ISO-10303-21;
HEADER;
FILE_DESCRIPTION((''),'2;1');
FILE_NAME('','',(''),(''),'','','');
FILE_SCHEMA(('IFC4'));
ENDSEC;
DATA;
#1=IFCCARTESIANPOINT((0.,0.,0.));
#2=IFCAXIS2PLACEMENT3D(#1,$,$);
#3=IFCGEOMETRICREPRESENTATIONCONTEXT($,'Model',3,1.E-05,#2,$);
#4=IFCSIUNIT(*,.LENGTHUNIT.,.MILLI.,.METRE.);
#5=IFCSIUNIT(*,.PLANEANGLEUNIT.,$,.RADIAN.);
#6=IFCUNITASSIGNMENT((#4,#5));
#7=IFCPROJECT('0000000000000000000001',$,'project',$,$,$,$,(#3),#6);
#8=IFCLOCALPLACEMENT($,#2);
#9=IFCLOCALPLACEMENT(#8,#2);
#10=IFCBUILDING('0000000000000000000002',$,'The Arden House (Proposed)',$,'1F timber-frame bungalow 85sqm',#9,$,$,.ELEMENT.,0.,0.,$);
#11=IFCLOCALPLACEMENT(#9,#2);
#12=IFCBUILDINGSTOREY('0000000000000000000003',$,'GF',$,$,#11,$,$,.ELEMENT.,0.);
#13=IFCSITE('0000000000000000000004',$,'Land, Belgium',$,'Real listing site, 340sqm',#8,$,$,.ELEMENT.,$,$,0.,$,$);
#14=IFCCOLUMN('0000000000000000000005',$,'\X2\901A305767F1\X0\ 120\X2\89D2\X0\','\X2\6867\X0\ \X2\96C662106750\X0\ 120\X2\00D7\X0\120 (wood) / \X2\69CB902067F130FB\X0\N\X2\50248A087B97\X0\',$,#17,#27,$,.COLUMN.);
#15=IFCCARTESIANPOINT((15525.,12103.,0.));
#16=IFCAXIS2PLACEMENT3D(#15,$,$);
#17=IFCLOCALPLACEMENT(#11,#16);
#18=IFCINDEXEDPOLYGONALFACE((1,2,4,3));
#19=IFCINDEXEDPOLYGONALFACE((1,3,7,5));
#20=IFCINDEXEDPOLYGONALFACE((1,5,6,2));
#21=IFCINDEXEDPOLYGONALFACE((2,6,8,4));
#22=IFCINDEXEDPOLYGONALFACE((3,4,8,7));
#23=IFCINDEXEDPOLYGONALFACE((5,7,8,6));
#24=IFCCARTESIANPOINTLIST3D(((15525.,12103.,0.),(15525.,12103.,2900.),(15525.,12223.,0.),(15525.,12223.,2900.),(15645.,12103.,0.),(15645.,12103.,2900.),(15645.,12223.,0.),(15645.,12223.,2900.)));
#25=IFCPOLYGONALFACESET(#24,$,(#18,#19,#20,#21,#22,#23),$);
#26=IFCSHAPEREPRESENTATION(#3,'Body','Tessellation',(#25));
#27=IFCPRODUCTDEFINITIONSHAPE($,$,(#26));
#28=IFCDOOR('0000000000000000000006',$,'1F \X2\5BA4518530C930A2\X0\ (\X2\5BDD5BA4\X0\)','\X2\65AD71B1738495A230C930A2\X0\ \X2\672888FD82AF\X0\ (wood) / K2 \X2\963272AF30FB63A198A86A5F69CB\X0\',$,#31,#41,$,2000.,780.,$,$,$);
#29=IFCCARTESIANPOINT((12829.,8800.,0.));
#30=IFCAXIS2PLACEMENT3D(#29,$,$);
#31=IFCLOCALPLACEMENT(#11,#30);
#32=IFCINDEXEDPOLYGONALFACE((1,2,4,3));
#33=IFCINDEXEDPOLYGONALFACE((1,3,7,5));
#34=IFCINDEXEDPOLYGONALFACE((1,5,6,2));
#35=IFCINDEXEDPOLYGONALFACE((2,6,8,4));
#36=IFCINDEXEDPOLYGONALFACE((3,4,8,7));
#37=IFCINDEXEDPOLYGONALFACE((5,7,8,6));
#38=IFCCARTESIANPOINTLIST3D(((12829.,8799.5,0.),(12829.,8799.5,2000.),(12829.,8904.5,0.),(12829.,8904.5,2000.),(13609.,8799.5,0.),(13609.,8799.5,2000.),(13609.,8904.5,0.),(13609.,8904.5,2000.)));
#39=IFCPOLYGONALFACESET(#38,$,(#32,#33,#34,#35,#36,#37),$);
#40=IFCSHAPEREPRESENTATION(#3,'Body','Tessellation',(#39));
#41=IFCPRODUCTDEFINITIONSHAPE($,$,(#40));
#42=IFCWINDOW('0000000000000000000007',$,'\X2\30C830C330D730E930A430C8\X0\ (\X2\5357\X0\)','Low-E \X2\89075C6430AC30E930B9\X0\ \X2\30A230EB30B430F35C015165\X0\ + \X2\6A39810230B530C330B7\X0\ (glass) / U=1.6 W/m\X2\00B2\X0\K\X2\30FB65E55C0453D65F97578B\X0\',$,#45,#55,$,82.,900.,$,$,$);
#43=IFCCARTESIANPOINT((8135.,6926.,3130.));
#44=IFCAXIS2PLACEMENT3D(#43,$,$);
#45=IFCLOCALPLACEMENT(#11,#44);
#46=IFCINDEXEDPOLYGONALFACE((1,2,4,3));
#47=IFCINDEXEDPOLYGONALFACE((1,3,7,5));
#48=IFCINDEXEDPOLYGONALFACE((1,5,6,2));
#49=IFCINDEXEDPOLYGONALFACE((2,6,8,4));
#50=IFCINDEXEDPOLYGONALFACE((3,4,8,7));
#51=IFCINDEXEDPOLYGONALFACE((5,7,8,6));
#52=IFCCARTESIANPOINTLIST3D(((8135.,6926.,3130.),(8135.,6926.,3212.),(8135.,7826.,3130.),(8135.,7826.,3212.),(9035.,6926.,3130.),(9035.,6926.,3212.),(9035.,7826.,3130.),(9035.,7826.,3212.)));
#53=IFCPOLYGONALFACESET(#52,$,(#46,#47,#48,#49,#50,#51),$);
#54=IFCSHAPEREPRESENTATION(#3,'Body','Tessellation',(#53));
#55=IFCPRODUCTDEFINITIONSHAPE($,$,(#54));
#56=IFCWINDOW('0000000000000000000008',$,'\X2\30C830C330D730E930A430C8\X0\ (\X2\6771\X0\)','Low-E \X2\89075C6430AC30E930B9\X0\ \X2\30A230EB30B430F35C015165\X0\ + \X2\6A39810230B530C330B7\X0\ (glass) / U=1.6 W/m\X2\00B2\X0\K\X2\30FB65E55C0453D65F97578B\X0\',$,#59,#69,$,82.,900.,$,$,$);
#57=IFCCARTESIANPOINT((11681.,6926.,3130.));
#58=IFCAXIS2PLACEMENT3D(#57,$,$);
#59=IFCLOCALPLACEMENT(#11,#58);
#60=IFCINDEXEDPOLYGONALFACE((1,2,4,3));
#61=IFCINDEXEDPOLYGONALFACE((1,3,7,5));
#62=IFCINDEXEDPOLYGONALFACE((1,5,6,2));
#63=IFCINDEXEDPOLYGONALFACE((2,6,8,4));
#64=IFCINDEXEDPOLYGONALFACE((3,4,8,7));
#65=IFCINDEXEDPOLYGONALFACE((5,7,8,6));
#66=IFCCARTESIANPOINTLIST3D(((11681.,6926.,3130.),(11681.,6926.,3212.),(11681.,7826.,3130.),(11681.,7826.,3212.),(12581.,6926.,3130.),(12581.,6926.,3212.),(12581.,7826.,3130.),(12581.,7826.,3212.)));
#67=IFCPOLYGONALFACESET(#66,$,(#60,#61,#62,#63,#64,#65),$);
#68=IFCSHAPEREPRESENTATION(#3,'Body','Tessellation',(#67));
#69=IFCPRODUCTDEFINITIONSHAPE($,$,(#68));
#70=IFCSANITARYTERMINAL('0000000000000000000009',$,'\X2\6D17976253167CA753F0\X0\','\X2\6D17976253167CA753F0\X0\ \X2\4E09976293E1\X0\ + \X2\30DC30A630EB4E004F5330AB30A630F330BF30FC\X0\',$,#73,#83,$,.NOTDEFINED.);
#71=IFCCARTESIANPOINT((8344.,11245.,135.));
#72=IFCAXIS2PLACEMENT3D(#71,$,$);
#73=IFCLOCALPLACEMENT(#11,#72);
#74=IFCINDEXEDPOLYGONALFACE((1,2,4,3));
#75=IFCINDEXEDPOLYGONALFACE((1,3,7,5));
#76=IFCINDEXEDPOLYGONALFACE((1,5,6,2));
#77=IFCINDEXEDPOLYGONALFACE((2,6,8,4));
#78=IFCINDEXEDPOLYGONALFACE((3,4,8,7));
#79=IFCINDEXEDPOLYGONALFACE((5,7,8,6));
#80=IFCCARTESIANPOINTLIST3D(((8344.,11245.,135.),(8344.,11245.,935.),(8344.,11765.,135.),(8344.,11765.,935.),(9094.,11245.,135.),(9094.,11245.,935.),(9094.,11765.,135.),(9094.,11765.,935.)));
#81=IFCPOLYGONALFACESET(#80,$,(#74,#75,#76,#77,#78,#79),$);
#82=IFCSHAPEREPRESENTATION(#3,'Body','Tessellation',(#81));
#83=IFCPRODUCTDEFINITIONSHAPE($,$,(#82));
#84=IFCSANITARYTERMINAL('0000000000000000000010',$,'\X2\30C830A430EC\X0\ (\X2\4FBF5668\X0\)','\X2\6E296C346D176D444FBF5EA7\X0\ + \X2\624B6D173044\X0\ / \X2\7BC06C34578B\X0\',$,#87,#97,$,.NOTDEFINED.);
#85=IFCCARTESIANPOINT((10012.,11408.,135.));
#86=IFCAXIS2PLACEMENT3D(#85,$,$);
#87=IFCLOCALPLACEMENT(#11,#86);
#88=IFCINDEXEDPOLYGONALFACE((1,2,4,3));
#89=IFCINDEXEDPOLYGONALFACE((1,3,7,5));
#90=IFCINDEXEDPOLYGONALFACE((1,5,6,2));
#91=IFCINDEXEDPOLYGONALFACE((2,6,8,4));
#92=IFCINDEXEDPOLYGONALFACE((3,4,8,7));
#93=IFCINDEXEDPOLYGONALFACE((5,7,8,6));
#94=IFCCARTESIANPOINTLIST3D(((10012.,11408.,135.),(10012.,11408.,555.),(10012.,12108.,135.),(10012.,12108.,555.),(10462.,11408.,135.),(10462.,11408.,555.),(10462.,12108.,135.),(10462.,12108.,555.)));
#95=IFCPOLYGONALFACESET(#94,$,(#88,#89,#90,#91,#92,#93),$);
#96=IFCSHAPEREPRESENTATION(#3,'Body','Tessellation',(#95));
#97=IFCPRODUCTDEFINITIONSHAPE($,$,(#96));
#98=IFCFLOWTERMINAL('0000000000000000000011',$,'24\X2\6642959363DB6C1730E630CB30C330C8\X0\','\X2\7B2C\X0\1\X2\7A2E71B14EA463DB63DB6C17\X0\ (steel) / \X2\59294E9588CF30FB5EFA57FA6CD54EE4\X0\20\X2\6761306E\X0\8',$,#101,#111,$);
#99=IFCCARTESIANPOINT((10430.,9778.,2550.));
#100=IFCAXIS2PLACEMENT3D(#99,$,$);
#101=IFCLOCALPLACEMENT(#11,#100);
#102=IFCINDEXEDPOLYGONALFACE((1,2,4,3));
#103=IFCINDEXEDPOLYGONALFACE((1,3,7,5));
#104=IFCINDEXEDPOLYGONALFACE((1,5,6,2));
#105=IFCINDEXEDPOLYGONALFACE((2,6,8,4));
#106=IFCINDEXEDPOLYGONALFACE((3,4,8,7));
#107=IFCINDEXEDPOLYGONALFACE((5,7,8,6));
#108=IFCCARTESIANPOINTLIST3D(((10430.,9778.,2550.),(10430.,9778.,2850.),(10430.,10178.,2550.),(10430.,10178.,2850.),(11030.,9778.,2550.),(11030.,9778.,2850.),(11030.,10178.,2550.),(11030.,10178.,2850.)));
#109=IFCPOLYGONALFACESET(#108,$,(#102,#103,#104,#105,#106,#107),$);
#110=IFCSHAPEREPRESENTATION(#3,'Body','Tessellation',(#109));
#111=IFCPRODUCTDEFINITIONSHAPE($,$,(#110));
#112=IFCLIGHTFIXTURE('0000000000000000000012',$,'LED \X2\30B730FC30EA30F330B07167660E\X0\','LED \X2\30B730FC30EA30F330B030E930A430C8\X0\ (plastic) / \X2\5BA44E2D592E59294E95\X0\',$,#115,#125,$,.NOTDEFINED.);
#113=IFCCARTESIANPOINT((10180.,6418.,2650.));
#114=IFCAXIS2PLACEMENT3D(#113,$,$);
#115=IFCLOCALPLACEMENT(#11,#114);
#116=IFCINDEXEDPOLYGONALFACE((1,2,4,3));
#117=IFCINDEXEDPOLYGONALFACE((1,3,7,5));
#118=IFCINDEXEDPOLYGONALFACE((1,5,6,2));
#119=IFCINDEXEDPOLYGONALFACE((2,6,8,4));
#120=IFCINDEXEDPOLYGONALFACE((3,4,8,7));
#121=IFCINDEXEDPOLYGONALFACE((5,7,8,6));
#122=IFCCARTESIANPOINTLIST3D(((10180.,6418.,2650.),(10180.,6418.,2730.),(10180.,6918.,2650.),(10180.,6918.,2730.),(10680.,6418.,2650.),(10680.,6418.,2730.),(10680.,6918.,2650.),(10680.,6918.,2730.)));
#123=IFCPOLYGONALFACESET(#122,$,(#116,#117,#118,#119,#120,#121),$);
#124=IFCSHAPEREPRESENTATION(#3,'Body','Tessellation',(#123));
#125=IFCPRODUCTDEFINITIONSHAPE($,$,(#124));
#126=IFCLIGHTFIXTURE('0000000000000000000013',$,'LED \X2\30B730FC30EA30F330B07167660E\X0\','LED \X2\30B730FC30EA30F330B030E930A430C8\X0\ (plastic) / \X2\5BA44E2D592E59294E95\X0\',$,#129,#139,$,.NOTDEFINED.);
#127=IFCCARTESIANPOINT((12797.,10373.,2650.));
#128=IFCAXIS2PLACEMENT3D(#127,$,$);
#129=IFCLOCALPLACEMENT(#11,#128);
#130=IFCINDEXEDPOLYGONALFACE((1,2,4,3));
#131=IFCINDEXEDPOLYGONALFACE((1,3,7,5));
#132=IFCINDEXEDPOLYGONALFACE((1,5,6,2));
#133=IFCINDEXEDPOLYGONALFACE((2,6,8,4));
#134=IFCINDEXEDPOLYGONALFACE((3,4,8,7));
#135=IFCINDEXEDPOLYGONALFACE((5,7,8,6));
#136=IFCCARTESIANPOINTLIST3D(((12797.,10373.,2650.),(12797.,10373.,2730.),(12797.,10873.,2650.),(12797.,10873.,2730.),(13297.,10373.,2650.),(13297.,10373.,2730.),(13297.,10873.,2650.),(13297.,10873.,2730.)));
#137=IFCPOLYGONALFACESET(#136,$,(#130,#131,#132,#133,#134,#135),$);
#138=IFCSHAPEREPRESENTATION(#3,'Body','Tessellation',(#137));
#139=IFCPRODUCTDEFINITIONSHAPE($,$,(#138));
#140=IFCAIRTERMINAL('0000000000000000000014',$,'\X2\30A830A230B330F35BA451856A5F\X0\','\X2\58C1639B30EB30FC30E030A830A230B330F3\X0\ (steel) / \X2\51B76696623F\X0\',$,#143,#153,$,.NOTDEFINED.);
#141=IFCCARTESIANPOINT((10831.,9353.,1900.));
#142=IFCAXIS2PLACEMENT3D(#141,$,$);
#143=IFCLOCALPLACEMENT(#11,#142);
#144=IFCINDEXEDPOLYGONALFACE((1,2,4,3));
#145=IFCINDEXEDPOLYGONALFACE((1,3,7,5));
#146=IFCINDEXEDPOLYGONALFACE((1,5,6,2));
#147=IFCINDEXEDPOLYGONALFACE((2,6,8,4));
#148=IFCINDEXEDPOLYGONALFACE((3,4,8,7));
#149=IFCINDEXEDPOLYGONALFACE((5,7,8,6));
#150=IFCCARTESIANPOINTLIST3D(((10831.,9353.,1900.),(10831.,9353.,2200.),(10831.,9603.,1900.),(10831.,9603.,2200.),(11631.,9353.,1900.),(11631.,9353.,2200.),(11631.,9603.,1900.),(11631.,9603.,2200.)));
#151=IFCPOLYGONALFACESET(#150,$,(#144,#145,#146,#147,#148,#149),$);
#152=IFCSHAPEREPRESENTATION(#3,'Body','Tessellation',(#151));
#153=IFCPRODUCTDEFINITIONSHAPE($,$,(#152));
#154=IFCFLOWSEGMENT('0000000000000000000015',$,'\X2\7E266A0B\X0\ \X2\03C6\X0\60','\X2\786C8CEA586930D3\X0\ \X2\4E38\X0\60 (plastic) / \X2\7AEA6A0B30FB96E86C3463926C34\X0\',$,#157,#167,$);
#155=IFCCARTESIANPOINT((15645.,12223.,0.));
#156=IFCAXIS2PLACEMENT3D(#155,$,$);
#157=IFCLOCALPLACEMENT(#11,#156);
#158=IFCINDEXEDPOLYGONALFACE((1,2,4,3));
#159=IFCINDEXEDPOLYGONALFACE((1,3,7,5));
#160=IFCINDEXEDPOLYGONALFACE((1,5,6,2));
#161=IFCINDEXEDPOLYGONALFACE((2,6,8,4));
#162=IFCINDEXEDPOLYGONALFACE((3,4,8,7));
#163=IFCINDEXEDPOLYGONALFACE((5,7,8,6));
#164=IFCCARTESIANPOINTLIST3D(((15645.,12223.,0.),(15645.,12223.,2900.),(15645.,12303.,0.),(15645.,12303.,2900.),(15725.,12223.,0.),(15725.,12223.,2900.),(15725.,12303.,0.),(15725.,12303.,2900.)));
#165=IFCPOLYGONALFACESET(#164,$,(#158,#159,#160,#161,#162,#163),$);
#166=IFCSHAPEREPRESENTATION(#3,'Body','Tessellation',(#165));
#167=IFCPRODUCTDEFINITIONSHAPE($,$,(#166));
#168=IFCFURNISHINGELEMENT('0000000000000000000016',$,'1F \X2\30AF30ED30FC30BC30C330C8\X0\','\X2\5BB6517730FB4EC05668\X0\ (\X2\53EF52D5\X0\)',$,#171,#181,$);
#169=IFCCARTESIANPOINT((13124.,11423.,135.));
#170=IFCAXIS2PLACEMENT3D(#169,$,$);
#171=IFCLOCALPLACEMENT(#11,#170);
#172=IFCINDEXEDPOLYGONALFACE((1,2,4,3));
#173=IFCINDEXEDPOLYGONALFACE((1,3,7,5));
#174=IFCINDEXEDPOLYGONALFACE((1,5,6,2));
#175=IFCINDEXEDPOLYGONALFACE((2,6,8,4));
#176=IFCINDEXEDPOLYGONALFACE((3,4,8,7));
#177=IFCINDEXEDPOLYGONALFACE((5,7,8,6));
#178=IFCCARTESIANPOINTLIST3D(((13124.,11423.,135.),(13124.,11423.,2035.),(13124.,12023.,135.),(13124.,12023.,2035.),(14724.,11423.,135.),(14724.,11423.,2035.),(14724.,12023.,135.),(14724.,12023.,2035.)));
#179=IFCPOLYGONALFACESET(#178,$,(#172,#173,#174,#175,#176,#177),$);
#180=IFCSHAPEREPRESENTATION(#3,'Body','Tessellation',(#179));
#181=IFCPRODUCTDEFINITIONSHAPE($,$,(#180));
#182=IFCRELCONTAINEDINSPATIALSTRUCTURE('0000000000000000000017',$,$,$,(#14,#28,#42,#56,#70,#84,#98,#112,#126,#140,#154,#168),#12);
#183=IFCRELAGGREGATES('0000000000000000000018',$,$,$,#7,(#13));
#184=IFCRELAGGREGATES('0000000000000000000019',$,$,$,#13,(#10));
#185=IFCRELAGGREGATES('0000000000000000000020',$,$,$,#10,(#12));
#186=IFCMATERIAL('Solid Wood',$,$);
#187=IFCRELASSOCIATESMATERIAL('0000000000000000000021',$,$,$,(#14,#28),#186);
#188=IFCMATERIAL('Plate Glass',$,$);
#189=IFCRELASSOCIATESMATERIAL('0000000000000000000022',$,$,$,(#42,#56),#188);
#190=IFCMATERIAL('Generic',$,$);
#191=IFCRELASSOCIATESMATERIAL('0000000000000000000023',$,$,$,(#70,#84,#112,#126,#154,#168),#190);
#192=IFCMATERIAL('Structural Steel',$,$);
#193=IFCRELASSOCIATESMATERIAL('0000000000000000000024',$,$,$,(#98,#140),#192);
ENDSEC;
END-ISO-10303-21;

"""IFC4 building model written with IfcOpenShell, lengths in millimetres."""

from ifc_helpers import new_model, si_unit, frame, frame_2d, origin, place, context, project, spatial, rectangle, extrude, material, element, save


model = new_model("IFC4")

# Units and contexts
model_context = context("Model", 3, precision=1e-05, world=origin())
ifc_project = project(units=[si_unit("LENGTHUNIT", "METRE", prefix="MILLI"), si_unit("PLANEANGLEUNIT", "RADIAN")], contexts=[model_context])

# Site, building, storey
site_placement = place(None, origin())
site = spatial("IfcSite", under=ifc_project, at=site_placement, Name="Land, Belgium", ObjectType="Real listing site, 340sqm", CompositionType="ELEMENT", RefElevation=0.0)
building_placement = place(site_placement, origin())
building = spatial("IfcBuilding", under=site, at=building_placement, Name="The Arden House (Proposed)", ObjectType="1F timber-frame bungalow 85sqm", CompositionType="ELEMENT", ElevationOfRefHeight=0.0, ElevationOfTerrain=0.0)
storey_placement = place(building_placement, origin())
storey = spatial("IfcBuildingStorey", under=building, at=storey_placement, Name="GF", CompositionType="ELEMENT", Elevation=0.0)

# Column
ifc_material_1 = material(Name="Solid Wood")
column_1_placement = place(storey_placement, frame((15525.0, 12103.0, 0.0)))
element("IfcColumn", 1, at=column_1_placement, inside=storey, material=ifc_material_1, Name="通し柱 120角", Description="桧 集成材 120×120 (wood) / 構造柱・N値計算", PredefinedType="COLUMN", context=model_context, shape_type="SweptSolid", body=[
    extrude(rectangle(XDim=120.0, YDim=120.0, at=frame_2d((60.0, 60.0))), frame((15525.0, 12103.0, 0.0)), (0.0, 0.0, 1.0), 2900.0),
])

# Door
door_placement = place(storey_placement, frame((12829.0, 8800.0, 0.0)))
element("IfcDoor", 2, at=door_placement, inside=storey, material=ifc_material_1, Name="1F 室内ドア (寝室)", Description="断熱玄関ドア 木製芯 (wood) / K2 防犯・採風機構", OverallHeight=2000.0, OverallWidth=780.0, context=model_context, shape_type="SweptSolid", body=[
    extrude(rectangle(XDim=780.0, YDim=105.0, at=frame_2d((390.0, 52.0))), frame((12829.0, 8800.0, 0.0)), (0.0, 0.0, 1.0), 2000.0),
])

# Windows
ifc_material_2 = material(Name="Plate Glass")
window_1_placement = place(storey_placement, frame((8135.0, 6926.0, 3130.0)))
element("IfcWindow", 3, at=window_1_placement, inside=storey, material=ifc_material_2, Name="トップライト (南)", Description="Low-E 複層ガラス アルゴン封入 + 樹脂サッシ (glass) / U=1.6 W/m²K・日射取得型", OverallHeight=82.0, OverallWidth=900.0, context=model_context, shape_type="SweptSolid", body=[
    extrude(rectangle(XDim=900.0, YDim=900.0, at=frame_2d((450.0, 450.0))), frame((8135.0, 6926.0, 3130.0)), (0.0, 0.0, 1.0), 82.0),
])
window_2_placement = place(storey_placement, frame((11681.0, 6926.0, 3130.0)))
element("IfcWindow", 4, at=window_2_placement, inside=storey, material=ifc_material_2, Name="トップライト (東)", Description="Low-E 複層ガラス アルゴン封入 + 樹脂サッシ (glass) / U=1.6 W/m²K・日射取得型", OverallHeight=82.0, OverallWidth=900.0, context=model_context, shape_type="SweptSolid", body=[
    extrude(rectangle(XDim=900.0, YDim=900.0, at=frame_2d((450.0, 450.0))), frame((11681.0, 6926.0, 3130.0)), (0.0, 0.0, 1.0), 82.0),
])

# Sanitary terminals
ifc_material_3 = material(Name="Generic")
sanitary_terminal_1_placement = place(storey_placement, frame((8344.0, 11245.0, 135.0)))
element("IfcSanitaryTerminal", 5, at=sanitary_terminal_1_placement, inside=storey, material=ifc_material_3, Name="洗面化粧台", Description="洗面化粧台 三面鏡 + ボウル一体カウンター", PredefinedType="NOTDEFINED", context=model_context, shape_type="SweptSolid", body=[
    extrude(rectangle(XDim=750.0, YDim=520.0, at=frame_2d((375.0, 260.0))), frame((8344.0, 11245.0, 135.0)), (0.0, 0.0, 1.0), 800.0),
])
sanitary_terminal_2_placement = place(storey_placement, frame((10012.0, 11408.0, 135.0)))
element("IfcSanitaryTerminal", 6, at=sanitary_terminal_2_placement, inside=storey, material=ifc_material_3, Name="トイレ (便器)", Description="温水洗浄便座 + 手洗い / 節水型", PredefinedType="NOTDEFINED", context=model_context, shape_type="SweptSolid", body=[
    extrude(rectangle(XDim=450.0, YDim=700.0, at=frame_2d((225.0, 350.0))), frame((10012.0, 11408.0, 135.0)), (0.0, 0.0, 1.0), 420.0),
])

# Flow terminal
ifc_material_4 = material(Name="Structural Steel")
flow_terminal_placement = place(storey_placement, frame((10430.0, 9778.0, 2550.0)))
element("IfcFlowTerminal", 7, at=flow_terminal_placement, inside=storey, material=ifc_material_4, Name="24時間換気ユニット", Description="第1種熱交換換気 (steel) / 天井裏・建基法令20条の8", context=model_context, shape_type="SweptSolid", body=[
    extrude(rectangle(XDim=600.0, YDim=400.0, at=frame_2d((300.0, 200.0))), frame((10430.0, 9778.0, 2550.0)), (0.0, 0.0, 1.0), 300.0),
])

# Light fixtures
light_fixture_1_placement = place(storey_placement, frame((10180.0, 6418.0, 2650.0)))
element("IfcLightFixture", 8, at=light_fixture_1_placement, inside=storey, material=ifc_material_3, Name="LED シーリング照明", Description="LED シーリングライト (plastic) / 室中央天井", PredefinedType="NOTDEFINED", context=model_context, shape_type="SweptSolid", body=[
    extrude(rectangle(XDim=500.0, YDim=500.0, at=frame_2d((250.0, 250.0))), frame((10180.0, 6418.0, 2650.0)), (0.0, 0.0, 1.0), 80.0),
])
light_fixture_2_placement = place(storey_placement, frame((12797.0, 10373.0, 2650.0)))
element("IfcLightFixture", 9, at=light_fixture_2_placement, inside=storey, material=ifc_material_3, Name="LED シーリング照明", Description="LED シーリングライト (plastic) / 室中央天井", PredefinedType="NOTDEFINED", context=model_context, shape_type="SweptSolid", body=[
    extrude(rectangle(XDim=500.0, YDim=500.0, at=frame_2d((250.0, 250.0))), frame((12797.0, 10373.0, 2650.0)), (0.0, 0.0, 1.0), 80.0),
])

# Air terminal
air_terminal_placement = place(storey_placement, frame((10831.0, 9353.0, 1900.0)))
element("IfcAirTerminal", 10, at=air_terminal_placement, inside=storey, material=ifc_material_4, Name="エアコン室内機", Description="壁掛ルームエアコン (steel) / 冷暖房", PredefinedType="NOTDEFINED", context=model_context, shape_type="SweptSolid", body=[
    extrude(rectangle(XDim=800.0, YDim=250.0, at=frame_2d((400.0, 125.0))), frame((10831.0, 9353.0, 1900.0)), (0.0, 0.0, 1.0), 300.0),
])

# Flow segment
flow_segment_placement = place(storey_placement, frame((15645.0, 12223.0, 0.0)))
element("IfcFlowSegment", 11, at=flow_segment_placement, inside=storey, material=ifc_material_3, Name="縦樋 φ60", Description="硬質塩ビ 丸60 (plastic) / 竪樋・雨水排水", context=model_context, shape_type="SweptSolid", body=[
    extrude(rectangle(XDim=80.0, YDim=80.0, at=frame_2d((40.0, 40.0))), frame((15645.0, 12223.0, 0.0)), (0.0, 0.0, 1.0), 2900.0),
])

# Furnishing element
furnishing_placement = place(storey_placement, frame((13124.0, 11423.0, 135.0)))
element("IfcFurnishingElement", 12, at=furnishing_placement, inside=storey, material=ifc_material_3, Name="1F クローゼット", Description="家具・什器 (可動)", context=model_context, shape_type="SweptSolid", body=[
    extrude(rectangle(XDim=1600.0, YDim=600.0, at=frame_2d((800.0, 300.0))), frame((13124.0, 11423.0, 135.0)), (0.0, 0.0, 1.0), 1900.0),
])

save(model, "model.ifc")
